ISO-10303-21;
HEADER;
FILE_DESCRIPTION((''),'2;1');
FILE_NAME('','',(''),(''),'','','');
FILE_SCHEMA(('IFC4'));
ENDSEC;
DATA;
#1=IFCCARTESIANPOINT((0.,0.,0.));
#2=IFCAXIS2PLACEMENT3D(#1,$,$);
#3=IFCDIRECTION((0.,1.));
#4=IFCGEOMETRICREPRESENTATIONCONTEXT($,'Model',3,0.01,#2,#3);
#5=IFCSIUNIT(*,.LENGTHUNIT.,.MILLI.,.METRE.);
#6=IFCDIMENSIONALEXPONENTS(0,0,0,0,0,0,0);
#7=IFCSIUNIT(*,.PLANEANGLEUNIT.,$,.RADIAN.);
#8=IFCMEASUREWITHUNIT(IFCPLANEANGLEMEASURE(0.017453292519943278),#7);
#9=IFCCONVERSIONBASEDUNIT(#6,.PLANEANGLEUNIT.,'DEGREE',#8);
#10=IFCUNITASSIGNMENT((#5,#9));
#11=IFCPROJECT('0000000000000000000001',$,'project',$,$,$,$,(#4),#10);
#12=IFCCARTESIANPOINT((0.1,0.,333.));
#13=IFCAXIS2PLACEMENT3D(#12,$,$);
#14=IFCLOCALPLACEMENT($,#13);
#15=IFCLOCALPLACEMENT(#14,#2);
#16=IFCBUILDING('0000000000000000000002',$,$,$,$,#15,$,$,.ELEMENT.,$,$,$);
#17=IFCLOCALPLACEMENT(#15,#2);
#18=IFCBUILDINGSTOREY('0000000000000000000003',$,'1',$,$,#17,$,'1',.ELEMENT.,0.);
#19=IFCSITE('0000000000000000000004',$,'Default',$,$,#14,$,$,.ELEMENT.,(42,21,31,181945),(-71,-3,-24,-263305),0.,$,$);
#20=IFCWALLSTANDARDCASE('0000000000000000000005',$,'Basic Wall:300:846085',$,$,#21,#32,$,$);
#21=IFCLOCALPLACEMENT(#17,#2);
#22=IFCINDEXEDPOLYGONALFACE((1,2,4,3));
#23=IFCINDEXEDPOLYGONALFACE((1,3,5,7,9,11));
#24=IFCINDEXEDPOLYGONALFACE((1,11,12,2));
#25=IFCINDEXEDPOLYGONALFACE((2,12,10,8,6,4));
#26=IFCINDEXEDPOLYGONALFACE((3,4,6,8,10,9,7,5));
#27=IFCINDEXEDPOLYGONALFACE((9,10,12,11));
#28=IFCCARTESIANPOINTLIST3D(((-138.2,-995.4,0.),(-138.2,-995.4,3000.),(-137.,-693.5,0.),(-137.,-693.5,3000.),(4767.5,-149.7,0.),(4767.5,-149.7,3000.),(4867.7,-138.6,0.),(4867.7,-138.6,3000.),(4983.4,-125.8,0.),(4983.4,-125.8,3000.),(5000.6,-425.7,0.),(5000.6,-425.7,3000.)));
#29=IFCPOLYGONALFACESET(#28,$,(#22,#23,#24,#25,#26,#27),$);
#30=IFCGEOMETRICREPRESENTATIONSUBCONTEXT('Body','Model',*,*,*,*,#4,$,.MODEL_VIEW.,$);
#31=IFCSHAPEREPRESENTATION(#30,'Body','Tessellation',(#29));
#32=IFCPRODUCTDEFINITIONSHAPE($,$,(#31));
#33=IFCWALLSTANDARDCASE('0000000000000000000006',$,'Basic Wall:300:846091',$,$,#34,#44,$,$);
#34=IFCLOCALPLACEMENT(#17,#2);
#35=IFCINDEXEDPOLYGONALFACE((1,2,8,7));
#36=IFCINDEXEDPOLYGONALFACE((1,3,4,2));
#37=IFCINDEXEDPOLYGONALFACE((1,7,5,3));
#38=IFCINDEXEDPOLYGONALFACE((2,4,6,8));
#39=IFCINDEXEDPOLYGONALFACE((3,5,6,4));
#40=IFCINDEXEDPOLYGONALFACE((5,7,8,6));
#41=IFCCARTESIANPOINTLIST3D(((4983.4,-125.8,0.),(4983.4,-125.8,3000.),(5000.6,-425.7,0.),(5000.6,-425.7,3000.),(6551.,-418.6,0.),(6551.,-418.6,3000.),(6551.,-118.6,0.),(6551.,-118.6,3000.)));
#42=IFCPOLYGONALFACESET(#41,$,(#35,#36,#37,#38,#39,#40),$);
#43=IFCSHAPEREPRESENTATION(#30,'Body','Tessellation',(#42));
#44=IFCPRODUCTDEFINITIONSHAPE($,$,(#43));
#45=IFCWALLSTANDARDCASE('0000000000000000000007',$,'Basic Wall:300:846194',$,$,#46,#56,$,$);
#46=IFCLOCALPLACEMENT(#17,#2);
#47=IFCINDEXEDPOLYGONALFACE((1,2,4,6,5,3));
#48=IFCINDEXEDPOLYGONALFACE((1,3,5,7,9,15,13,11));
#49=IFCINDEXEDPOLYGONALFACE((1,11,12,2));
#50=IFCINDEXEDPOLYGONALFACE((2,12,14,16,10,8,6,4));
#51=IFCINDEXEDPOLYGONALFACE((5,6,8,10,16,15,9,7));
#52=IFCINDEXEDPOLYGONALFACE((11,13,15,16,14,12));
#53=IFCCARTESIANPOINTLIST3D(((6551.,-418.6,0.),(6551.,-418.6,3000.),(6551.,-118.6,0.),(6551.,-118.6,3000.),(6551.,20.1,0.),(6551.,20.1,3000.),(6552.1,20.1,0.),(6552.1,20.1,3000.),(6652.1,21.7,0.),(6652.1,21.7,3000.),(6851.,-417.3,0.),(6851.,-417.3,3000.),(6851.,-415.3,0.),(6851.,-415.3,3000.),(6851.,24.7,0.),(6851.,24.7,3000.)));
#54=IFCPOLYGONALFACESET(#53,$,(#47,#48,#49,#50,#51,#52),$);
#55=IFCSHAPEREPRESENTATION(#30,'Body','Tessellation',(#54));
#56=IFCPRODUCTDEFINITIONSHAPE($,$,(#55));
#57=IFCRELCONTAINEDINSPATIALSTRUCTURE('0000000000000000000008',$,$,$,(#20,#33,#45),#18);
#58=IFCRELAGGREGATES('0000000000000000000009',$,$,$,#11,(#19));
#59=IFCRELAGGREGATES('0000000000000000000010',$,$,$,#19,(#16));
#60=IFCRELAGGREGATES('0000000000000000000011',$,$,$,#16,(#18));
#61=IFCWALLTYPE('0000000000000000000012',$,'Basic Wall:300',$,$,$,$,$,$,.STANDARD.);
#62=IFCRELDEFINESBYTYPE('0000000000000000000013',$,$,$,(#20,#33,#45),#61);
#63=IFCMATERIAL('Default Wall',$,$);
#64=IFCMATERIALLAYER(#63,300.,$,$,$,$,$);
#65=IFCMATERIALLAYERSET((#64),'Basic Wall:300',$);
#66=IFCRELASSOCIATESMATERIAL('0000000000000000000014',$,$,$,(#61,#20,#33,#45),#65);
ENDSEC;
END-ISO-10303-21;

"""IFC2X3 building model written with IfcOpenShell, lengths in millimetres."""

from ifc_helpers import new_model, entity, si_unit, converted_unit, direction, frame, origin, place, context, subcontext, project, spatial, polyline, outline, extrude, material, layer, layer_set, layer_usage, type_object, element, save


model = new_model("IFC2X3")

# Units and contexts
model_context = context("Model", 3, precision=0.01, world=origin(), true_north=direction((0.0, 1.0)))
body_context = subcontext(model_context, "Body", "Model", "MODEL_VIEW")
ifc_project = project(units=[si_unit("LENGTHUNIT", "METRE", prefix="MILLI"), converted_unit("PLANEANGLEUNIT", "DEGREE", entity("IfcPlaneAngleMeasure", 0.017453292519943278), si_unit("PLANEANGLEUNIT", "RADIAN"), dimensions=[0, 0, 0, 0, 0, 0, 0])], contexts=[model_context])

# Site, building, storey
site_placement = place(None, frame((0.1, 0.0, 333.0)))
site = spatial("IfcSite", under=ifc_project, at=site_placement, Name="Default", CompositionType="ELEMENT", RefLatitude=(42, 21, 31, 181945), RefLongitude=(-71, -3, -24, -263305), RefElevation=0.0)
building_placement = place(site_placement, origin())
building = spatial("IfcBuilding", under=site, at=building_placement, CompositionType="ELEMENT")
storey_placement = place(building_placement, origin())
storey = spatial("IfcBuildingStorey", under=building, at=storey_placement, Name="1", LongName="1", CompositionType="ELEMENT", Elevation=0.0)

# Walls
ifc_material_1 = material(Name="Default Wall")
ifc_layer_1 = layer(ifc_material_1, 300.0)
ifc_layer_set_1 = layer_set([ifc_layer_1], Name="Basic Wall:300")
ifc_layer_usage_1 = layer_usage(ifc_layer_set_1, "AXIS2", "NEGATIVE", 150.0)
wall_type_1 = type_object("IfcWallType", Name="Basic Wall:300", PredefinedType="STANDARD", material=ifc_layer_set_1)
wall_1_placement = place(storey_placement, frame((4999.9, -274.9, 0.0), z_axis=(0.0, 0.0, 1.0), x_axis=(-0.99391, -0.110193, 0.0)))
element("IfcWallStandardCase", 1, at=wall_1_placement, inside=storey, type_object=wall_type_1, material=ifc_layer_usage_1, Name="Basic Wall:300:846085", context=body_context, shape_type="SweptSolid", body=[
    extrude(outline(polyline([(5151.7, -150.0), (5186.2, 150.0), (15.9, 150.0), (0.0, -150.0), (116.4, -150.0), (217.2, -150.0), (5151.7, -150.0)])), origin(), (0.0, 0.0, 1.0), 3000.0),
])
ifc_layer_usage_2 = layer_usage(ifc_layer_set_1, "AXIS2", "NEGATIVE", 150.0)
wall_2_placement = place(storey_placement, frame((6551.7, -268.6, 0.0), z_axis=(0.0, 0.0, 1.0), x_axis=(-0.99999, -0.004545, 0.0)))
element("IfcWallStandardCase", 2, at=wall_2_placement, inside=storey, type_object=wall_type_1, material=ifc_layer_usage_2, Name="Basic Wall:300:846091", context=body_context, shape_type="SweptSolid", body=[
    extrude(outline(polyline([(1567.7, -150.0), (1551.8, 150.0), (1.4, 150.0), (0.0, -150.0), (1567.7, -150.0)])), origin(), (0.0, 0.0, 1.0), 3000.0),
])
ifc_layer_usage_3 = layer_usage(ifc_layer_set_1, "AXIS2", "NEGATIVE", 150.0)
wall_3_placement = place(storey_placement, frame((6701.0, 24.7, 0.0), z_axis=(0.0, 0.0, 1.0), x_axis=(0.0, -1.0, 0.0)))
element("IfcWallStandardCase", 3, at=wall_3_placement, inside=storey, type_object=wall_type_1, material=ifc_layer_usage_3, Name="Basic Wall:300:846194", context=body_context, shape_type="SweptSolid", body=[
    extrude(outline(polyline([(443.4, -150.0), (442.0, 150.0), (440.1, 150.0), (0.0, 150.0), (3.1, -48.9), (4.6, -148.9), (4.6, -150.0), (143.4, -150.0), (443.4, -150.0)])), origin(), (0.0, 0.0, 1.0), 3000.0),
])

save(model, "model.ifc")
